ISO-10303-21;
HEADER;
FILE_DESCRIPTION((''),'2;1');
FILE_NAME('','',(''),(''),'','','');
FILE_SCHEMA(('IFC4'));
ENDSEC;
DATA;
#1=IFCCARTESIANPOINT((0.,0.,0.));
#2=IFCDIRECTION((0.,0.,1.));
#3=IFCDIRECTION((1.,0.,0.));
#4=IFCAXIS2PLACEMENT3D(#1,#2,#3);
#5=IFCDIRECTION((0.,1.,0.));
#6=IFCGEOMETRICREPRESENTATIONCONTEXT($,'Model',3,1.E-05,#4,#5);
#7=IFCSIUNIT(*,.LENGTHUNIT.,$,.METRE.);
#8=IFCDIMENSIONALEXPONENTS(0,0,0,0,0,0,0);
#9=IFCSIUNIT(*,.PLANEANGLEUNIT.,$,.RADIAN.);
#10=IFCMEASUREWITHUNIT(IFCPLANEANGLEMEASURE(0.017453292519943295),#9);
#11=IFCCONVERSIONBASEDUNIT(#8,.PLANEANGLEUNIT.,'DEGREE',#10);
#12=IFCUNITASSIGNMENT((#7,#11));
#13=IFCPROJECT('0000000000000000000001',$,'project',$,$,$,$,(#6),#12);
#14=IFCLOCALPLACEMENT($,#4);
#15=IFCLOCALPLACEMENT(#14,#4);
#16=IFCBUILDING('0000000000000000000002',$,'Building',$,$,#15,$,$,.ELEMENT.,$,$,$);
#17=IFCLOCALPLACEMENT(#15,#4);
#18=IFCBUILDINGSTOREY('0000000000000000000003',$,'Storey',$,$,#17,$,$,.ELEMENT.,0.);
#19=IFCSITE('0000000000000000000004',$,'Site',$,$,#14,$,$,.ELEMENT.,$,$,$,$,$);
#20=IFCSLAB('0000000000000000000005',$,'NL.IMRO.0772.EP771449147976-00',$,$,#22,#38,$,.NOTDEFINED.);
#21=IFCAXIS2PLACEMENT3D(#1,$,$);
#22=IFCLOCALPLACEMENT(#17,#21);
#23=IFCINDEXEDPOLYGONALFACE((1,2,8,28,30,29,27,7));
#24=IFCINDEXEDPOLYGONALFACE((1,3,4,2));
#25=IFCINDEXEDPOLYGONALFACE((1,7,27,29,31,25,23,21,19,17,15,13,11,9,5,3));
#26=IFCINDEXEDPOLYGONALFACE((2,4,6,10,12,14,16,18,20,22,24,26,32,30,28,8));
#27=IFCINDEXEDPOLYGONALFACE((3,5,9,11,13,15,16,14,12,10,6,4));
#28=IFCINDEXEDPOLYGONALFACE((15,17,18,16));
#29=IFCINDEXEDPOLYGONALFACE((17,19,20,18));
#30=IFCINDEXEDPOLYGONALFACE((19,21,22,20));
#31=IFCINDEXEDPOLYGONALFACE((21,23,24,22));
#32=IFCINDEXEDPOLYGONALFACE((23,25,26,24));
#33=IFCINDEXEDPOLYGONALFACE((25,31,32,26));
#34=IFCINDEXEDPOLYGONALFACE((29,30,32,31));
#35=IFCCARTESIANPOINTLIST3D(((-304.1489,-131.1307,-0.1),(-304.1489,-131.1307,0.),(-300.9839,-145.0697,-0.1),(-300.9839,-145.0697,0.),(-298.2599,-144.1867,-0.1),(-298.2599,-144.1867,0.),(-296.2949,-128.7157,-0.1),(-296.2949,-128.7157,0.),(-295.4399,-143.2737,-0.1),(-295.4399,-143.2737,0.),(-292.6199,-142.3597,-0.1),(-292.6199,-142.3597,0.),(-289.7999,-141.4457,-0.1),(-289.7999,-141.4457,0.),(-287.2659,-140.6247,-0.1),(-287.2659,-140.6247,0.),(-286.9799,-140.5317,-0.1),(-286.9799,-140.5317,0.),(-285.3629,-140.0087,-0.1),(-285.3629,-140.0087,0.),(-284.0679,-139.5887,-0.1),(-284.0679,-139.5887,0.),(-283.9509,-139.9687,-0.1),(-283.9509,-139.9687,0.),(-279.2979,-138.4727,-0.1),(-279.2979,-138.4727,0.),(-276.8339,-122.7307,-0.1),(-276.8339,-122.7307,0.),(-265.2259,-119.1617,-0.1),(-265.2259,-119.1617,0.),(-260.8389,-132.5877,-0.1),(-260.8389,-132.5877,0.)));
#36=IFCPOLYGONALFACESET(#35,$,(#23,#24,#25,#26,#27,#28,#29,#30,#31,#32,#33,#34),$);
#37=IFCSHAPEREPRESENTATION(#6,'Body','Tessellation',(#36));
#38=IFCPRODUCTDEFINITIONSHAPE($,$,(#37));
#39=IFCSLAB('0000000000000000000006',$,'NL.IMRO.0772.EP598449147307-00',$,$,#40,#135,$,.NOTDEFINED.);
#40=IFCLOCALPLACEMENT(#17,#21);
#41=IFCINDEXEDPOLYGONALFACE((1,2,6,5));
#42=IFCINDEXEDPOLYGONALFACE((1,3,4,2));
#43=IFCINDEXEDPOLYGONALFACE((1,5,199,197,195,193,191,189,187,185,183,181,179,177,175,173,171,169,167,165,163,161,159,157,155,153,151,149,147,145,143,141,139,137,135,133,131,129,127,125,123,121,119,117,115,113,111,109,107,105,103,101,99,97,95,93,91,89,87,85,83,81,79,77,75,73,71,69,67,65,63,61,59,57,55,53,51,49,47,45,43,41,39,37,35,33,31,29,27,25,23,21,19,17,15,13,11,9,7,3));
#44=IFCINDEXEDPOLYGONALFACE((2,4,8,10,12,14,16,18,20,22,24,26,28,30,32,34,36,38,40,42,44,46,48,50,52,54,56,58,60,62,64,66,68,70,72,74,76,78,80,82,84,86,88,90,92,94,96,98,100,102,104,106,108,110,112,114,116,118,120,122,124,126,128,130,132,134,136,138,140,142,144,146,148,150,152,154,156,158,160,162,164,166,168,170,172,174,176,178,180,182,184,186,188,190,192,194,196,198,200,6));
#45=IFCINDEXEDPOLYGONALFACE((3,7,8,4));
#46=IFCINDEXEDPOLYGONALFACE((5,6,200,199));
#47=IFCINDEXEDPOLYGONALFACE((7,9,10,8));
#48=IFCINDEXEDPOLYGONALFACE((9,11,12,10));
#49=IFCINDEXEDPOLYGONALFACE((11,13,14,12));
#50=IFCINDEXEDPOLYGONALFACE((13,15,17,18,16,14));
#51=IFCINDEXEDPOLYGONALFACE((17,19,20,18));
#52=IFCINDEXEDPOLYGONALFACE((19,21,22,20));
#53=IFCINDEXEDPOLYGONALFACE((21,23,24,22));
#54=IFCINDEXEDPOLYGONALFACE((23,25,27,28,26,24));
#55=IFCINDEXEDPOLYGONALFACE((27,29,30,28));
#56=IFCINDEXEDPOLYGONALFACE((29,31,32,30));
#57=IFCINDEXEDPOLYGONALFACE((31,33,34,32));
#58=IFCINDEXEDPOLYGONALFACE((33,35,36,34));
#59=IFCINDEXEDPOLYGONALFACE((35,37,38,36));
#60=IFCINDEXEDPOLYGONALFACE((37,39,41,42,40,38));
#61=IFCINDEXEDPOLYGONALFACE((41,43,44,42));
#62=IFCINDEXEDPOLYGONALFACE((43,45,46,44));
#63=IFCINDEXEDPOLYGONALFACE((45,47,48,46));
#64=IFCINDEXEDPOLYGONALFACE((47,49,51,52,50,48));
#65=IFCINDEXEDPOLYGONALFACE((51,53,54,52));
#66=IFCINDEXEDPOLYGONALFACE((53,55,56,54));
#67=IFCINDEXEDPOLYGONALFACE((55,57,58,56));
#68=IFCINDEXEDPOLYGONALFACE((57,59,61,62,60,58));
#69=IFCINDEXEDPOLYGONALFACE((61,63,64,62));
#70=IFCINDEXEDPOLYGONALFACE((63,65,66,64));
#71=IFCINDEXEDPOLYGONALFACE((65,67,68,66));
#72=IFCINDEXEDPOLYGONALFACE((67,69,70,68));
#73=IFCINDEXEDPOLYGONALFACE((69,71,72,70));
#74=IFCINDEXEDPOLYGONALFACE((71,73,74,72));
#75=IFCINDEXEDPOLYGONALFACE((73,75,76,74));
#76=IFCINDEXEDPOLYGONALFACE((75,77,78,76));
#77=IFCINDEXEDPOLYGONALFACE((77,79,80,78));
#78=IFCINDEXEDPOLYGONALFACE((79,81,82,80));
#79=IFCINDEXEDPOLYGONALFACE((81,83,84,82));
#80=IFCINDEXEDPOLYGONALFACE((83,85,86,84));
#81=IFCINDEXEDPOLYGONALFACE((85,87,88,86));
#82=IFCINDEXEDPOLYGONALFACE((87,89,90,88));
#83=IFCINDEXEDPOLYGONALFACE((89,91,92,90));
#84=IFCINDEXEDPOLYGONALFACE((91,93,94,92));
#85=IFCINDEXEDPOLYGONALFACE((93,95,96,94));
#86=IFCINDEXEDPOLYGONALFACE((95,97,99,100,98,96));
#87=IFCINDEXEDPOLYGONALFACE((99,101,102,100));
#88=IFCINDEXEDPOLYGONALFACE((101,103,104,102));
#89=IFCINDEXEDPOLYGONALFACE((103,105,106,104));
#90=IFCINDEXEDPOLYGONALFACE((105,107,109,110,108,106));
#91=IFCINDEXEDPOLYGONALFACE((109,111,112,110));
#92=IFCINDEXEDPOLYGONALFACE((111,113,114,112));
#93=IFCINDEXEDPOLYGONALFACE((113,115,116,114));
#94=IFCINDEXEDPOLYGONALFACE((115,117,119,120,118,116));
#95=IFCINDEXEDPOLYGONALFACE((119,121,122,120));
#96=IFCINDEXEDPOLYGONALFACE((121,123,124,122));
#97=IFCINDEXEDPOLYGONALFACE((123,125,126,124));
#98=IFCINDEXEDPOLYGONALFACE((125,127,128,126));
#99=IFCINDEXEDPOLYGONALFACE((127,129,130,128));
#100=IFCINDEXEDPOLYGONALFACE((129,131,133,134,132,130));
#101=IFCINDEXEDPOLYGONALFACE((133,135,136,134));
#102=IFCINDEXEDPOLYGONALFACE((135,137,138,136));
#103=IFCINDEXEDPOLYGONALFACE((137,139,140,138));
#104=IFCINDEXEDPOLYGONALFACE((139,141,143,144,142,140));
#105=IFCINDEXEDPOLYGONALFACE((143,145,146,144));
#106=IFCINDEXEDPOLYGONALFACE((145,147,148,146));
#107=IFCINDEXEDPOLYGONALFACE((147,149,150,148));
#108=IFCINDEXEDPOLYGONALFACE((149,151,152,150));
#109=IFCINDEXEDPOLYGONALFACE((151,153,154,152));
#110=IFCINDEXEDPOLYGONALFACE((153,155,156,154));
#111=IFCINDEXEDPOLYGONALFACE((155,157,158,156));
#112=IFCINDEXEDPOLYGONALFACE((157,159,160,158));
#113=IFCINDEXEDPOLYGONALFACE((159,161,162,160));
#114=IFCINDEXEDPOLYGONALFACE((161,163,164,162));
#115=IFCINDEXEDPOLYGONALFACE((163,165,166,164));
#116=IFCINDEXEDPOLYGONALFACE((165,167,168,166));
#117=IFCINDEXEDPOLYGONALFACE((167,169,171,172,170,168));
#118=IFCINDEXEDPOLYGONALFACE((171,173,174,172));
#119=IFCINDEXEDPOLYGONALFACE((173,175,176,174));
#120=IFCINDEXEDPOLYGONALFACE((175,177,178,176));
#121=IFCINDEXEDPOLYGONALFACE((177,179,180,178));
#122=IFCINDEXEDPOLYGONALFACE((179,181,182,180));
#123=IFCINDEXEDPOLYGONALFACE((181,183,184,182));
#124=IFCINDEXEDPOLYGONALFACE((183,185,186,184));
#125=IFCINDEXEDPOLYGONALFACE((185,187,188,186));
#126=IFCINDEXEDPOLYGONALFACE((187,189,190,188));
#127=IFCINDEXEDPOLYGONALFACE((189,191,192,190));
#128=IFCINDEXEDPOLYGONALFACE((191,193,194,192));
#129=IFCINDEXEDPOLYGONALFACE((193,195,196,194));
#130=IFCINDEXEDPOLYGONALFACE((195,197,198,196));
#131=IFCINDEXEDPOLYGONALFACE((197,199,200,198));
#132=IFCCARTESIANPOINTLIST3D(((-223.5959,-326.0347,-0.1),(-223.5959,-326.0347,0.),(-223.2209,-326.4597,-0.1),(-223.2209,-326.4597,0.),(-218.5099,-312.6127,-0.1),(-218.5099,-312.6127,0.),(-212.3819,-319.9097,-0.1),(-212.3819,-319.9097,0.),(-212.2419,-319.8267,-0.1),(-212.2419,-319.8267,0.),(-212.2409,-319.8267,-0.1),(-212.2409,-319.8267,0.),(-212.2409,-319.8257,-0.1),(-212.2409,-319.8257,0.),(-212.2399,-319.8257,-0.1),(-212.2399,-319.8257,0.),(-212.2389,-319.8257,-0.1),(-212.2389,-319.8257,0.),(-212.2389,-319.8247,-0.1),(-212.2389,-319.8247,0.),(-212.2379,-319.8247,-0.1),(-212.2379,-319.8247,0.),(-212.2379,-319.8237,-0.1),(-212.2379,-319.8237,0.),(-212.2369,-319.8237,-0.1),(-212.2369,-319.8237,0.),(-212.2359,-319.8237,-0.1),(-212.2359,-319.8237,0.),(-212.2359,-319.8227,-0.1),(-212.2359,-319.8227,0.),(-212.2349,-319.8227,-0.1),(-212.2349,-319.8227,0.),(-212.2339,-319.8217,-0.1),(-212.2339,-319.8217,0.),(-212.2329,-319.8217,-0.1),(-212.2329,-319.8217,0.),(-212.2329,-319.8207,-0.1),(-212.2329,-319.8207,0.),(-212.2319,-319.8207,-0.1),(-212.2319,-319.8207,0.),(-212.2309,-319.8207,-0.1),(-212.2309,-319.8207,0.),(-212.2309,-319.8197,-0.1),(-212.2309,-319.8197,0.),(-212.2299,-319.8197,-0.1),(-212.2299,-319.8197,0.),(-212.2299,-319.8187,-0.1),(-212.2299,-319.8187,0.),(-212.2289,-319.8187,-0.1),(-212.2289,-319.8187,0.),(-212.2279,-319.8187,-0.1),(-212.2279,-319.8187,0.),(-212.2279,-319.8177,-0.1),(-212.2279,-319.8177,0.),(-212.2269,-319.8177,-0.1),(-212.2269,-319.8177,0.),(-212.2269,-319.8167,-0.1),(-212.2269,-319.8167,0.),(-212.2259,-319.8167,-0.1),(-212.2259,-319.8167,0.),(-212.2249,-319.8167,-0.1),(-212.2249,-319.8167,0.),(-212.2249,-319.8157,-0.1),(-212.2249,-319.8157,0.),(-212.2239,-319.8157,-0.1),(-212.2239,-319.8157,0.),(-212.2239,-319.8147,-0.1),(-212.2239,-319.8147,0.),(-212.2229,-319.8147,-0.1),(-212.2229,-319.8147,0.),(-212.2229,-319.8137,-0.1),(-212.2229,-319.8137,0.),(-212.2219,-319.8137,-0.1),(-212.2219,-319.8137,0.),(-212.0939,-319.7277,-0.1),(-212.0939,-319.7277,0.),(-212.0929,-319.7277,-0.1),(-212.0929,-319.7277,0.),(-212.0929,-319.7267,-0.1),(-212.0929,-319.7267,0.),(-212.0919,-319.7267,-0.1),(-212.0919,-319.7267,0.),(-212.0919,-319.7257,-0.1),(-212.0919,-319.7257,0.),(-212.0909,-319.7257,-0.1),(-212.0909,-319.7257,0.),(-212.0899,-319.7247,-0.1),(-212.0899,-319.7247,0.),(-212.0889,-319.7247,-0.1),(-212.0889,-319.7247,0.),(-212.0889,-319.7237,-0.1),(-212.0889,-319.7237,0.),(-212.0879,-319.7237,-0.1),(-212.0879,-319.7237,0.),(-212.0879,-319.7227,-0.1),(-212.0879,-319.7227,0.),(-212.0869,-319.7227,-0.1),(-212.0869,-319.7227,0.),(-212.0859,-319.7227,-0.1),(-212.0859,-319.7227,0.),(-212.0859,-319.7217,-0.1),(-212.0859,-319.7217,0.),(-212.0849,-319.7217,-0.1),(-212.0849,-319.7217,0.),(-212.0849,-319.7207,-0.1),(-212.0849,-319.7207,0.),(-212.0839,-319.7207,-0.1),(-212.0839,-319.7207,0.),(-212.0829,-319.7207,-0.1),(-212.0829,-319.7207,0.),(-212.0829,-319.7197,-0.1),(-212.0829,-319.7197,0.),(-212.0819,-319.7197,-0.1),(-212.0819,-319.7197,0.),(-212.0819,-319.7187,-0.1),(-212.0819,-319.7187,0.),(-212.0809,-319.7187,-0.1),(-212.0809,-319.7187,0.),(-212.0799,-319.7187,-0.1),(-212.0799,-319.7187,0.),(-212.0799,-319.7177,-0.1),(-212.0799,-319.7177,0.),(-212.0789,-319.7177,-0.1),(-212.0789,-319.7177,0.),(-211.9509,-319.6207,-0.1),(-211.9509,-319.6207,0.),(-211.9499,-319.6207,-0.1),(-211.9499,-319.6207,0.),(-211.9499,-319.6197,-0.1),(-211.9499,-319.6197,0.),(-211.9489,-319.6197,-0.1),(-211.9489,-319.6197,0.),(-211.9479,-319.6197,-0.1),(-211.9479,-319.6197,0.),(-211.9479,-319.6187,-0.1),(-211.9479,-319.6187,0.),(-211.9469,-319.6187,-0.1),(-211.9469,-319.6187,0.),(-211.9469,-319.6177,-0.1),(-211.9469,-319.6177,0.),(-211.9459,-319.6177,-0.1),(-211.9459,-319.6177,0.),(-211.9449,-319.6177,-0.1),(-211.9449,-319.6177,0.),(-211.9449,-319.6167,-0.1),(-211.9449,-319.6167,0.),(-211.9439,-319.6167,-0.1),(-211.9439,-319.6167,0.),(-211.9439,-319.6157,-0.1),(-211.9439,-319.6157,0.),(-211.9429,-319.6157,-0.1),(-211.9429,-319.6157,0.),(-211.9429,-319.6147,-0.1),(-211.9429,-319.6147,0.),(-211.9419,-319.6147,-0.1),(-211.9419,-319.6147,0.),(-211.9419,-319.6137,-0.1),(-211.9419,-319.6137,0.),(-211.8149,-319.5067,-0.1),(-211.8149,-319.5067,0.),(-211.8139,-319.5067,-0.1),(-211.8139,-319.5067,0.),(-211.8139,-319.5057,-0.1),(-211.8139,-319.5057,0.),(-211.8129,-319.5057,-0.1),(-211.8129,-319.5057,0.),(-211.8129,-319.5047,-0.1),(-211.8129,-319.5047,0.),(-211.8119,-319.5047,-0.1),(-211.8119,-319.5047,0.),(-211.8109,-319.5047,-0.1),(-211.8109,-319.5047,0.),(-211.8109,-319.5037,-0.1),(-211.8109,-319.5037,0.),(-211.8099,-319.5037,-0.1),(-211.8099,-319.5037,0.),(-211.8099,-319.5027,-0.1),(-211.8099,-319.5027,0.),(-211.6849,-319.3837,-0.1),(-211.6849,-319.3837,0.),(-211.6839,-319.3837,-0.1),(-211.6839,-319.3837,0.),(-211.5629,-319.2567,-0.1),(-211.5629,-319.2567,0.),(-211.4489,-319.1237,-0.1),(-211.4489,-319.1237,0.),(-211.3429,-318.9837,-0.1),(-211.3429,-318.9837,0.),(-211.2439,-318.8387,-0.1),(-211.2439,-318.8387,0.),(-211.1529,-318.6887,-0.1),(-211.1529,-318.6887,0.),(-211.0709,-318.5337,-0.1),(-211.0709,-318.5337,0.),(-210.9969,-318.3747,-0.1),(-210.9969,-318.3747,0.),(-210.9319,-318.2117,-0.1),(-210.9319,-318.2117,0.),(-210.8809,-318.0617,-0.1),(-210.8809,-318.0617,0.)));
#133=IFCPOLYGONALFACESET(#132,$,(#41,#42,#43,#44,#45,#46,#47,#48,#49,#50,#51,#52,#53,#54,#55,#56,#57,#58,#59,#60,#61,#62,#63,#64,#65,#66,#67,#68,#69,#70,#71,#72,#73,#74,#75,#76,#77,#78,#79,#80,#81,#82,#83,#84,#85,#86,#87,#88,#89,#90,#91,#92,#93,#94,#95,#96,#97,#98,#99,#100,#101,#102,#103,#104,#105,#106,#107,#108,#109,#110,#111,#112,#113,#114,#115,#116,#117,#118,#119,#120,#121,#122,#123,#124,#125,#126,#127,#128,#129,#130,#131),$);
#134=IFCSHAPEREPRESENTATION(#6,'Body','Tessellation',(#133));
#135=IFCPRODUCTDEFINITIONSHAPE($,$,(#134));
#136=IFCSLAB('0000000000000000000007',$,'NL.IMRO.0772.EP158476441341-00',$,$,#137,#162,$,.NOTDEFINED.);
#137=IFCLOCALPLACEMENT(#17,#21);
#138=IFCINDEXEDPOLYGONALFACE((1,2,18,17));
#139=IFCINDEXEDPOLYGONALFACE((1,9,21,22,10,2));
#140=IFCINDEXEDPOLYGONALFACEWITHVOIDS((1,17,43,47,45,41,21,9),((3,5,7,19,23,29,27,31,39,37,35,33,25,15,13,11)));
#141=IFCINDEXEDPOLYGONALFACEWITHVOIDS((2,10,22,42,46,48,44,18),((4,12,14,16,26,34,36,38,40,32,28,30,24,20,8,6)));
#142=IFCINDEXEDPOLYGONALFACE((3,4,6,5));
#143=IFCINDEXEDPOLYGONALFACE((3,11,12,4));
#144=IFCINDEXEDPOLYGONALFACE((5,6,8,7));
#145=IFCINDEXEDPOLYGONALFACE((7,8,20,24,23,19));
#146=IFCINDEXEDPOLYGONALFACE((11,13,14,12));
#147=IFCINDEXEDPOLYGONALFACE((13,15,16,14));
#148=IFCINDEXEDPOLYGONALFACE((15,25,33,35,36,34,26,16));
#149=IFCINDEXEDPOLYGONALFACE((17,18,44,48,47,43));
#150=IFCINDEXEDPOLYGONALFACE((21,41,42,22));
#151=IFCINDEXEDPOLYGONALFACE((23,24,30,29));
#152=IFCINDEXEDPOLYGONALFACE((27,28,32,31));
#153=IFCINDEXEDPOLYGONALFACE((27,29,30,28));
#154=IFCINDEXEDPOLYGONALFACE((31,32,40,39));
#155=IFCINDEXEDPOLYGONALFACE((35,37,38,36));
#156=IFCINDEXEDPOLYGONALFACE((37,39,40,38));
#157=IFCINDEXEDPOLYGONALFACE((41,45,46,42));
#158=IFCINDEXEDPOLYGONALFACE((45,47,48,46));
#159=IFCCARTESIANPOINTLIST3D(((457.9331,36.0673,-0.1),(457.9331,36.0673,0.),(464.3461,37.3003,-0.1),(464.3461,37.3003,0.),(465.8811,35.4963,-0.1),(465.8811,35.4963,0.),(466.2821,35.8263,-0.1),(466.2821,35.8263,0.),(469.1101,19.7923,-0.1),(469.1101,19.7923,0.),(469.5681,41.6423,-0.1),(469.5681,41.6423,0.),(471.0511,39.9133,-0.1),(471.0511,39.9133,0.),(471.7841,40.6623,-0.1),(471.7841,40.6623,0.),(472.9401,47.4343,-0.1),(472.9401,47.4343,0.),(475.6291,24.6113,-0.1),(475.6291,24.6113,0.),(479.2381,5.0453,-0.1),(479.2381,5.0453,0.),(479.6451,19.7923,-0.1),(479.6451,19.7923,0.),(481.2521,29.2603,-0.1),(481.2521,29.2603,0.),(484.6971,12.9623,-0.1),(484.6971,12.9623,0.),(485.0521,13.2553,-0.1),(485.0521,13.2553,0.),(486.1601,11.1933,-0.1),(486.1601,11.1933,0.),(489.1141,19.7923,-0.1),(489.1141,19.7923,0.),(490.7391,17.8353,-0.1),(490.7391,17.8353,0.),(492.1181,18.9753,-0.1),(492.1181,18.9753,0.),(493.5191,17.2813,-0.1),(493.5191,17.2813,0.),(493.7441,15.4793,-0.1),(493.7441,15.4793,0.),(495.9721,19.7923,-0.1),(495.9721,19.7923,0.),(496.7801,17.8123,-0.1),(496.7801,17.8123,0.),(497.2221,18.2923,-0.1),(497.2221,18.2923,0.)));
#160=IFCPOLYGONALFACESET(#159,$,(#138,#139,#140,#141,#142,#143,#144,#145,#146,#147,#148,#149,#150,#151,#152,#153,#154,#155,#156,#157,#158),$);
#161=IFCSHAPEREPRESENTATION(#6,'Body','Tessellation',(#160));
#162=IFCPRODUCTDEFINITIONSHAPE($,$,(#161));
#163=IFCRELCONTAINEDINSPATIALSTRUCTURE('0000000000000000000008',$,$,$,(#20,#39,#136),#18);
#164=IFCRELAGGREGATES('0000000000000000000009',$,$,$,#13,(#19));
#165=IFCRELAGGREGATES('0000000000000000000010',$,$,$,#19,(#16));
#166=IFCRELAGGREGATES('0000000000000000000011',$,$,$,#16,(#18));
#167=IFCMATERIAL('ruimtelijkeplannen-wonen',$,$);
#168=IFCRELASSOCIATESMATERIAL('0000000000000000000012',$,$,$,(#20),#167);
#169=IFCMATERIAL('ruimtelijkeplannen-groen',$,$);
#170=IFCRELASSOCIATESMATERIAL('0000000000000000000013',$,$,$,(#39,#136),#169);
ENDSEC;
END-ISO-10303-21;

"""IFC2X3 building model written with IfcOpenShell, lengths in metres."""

from ifc_helpers import new_model, entity, si_unit, converted_unit, direction, frame, origin_with_axes, place, context, project, spatial, polyline, outline, extrude, material, element, save


model = new_model("IFC2X3")

# Units and contexts
model_context = context("Model", 3, precision=1e-05, world=origin_with_axes(), true_north=direction((0.0, 1.0, 0.0)))
ifc_project = project(units=[si_unit("LENGTHUNIT", "METRE"), converted_unit("PLANEANGLEUNIT", "DEGREE", entity("IfcPlaneAngleMeasure", 0.017453292519943295), si_unit("PLANEANGLEUNIT", "RADIAN"), dimensions=[0, 0, 0, 0, 0, 0, 0])], contexts=[model_context])

# Site, building, storey
site_placement = place(None, origin_with_axes())
site = spatial("IfcSite", under=ifc_project, at=site_placement, Name="Site", CompositionType="ELEMENT")
building_placement = place(site_placement, origin_with_axes())
building = spatial("IfcBuilding", under=site, at=building_placement, Name="Building", CompositionType="ELEMENT")
storey_placement = place(building_placement, origin_with_axes())
storey = spatial("IfcBuildingStorey", under=building, at=storey_placement, Name="Storey", CompositionType="ELEMENT", Elevation=0.0)

# Slabs
ifc_material_1 = material(Name="ruimtelijkeplannen-wonen")
slab_1_placement = place(storey_placement, frame((0.0, 0.0, -0.1), z_axis=(0.0, 0.0, 1.0), x_axis=(1.0, 0.0, 0.0)))
element("IfcSlab", 1, at=slab_1_placement, inside=storey, material=ifc_material_1, Name="NL.IMRO.0772.EP771449147976-00", PredefinedType="NOTDEFINED", context=model_context, shape_type="SweptSolid", body=[
    extrude(outline(polyline([(-260.8389, -132.5877), (-279.2979, -138.4727), (-283.9509, -139.9687), (-284.0679, -139.5887), (-285.3629, -140.0087), (-286.9799, -140.5317), (-287.2659, -140.6247), (-289.7999, -141.4457), (-292.6199, -142.3597), (-295.4399, -143.2737), (-298.2599, -144.1867), (-300.9839, -145.0697), (-304.1489, -131.1307), (-296.2949, -128.7157), (-276.8339, -122.7307), (-265.2259, -119.1617), (-260.8389, -132.5877)])), origin_with_axes(), (0.0, 0.0, 1.0), 0.1),
])
ifc_material_2 = material(Name="ruimtelijkeplannen-groen")
slab_2_placement = place(storey_placement, frame((0.0, 0.0, -0.1), z_axis=(0.0, 0.0, 1.0), x_axis=(1.0, 0.0, 0.0)))
element("IfcSlab", 2, at=slab_2_placement, inside=storey, material=ifc_material_2, Name="NL.IMRO.0772.EP598449147307-00", PredefinedType="NOTDEFINED", context=model_context, shape_type="SweptSolid", body=[
    extrude(outline(polyline([(-212.2219, -319.8137), (-212.2229, -319.8137), (-212.2229, -319.8147), (-212.2239, -319.8147), (-212.2239, -319.8157), (-212.2249, -319.8157), (-212.2249, -319.8167), (-212.2259, -319.8167), (-212.2269, -319.8167), (-212.2269, -319.8177), (-212.2279, -319.8177), (-212.2279, -319.8187), (-212.2289, -319.8187), (-212.2299, -319.8187), (-212.2299, -319.8197), (-212.2309, -319.8197), (-212.2309, -319.8207), (-212.2319, -319.8207), (-212.2329, -319.8207), (-212.2329, -319.8217), (-212.2339, -319.8217), (-212.2349, -319.8227), (-212.2359, -319.8227), (-212.2359, -319.8237), (-212.2369, -319.8237), (-212.2379, -319.8237), (-212.2379, -319.8247), (-212.2389, -319.8247), (-212.2389, -319.8257), (-212.2399, -319.8257), (-212.2409, -319.8257), (-212.2409, -319.8267), (-212.2419, -319.8267), (-212.3819, -319.9097), (-223.2209, -326.4597), (-223.5959, -326.0347), (-218.5099, -312.6127), (-210.8809, -318.0617), (-210.9319, -318.2117), (-210.9969, -318.3747), (-211.0709, -318.5337), (-211.1529, -318.6887), (-211.2439, -318.8387), (-211.3429, -318.9837), (-211.4489, -319.1237), (-211.5629, -319.2567), (-211.6839, -319.3837), (-211.6849, -319.3837), (-211.8099, -319.5027), (-211.8099, -319.5037), (-211.8109, -319.5037), (-211.8109, -319.5047), (-211.8119, -319.5047), (-211.8129, -319.5047), (-211.8129, -319.5057), (-211.8139, -319.5057), (-211.8139, -319.5067), (-211.8149, -319.5067), (-211.9419, -319.6137), (-211.9419, -319.6147), (-211.9429, -319.6147), (-211.9429, -319.6157), (-211.9439, -319.6157), (-211.9439, -319.6167), (-211.9449, -319.6167), (-211.9449, -319.6177), (-211.9459, -319.6177), (-211.9469, -319.6177), (-211.9469, -319.6187), (-211.9479, -319.6187), (-211.9479, -319.6197), (-211.9489, -319.6197), (-211.9499, -319.6197), (-211.9499, -319.6207), (-211.9509, -319.6207), (-212.0789, -319.7177), (-212.0799, -319.7177), (-212.0799, -319.7187), (-212.0809, -319.7187), (-212.0819, -319.7187), (-212.0819, -319.7197), (-212.0829, -319.7197), (-212.0829, -319.7207), (-212.0839, -319.7207), (-212.0849, -319.7207), (-212.0849, -319.7217), (-212.0859, -319.7217), (-212.0859, -319.7227), (-212.0869, -319.7227), (-212.0879, -319.7227), (-212.0879, -319.7237), (-212.0889, -319.7237), (-212.0889, -319.7247), (-212.0899, -319.7247), (-212.0909, -319.7257), (-212.0919, -319.7257), (-212.0919, -319.7267), (-212.0929, -319.7267), (-212.0929, -319.7277), (-212.0939, -319.7277), (-212.2219, -319.8137)])), origin_with_axes(), (0.0, 0.0, 1.0), 0.1),
])
slab_3_placement = place(storey_placement, frame((0.0, 0.0, -0.1), z_axis=(0.0, 0.0, 1.0), x_axis=(1.0, 0.0, 0.0)))
element("IfcSlab", 3, at=slab_3_placement, inside=storey, material=ifc_material_2, Name="NL.IMRO.0772.EP158476441341-00", PredefinedType="NOTDEFINED", context=model_context, shape_type="SweptSolid", body=[
    extrude(outline(polyline([(493.7441, 15.4793), (479.2381, 5.0453), (469.1101, 19.7923), (457.9331, 36.0673), (472.9401, 47.4343), (495.9721, 19.7923), (497.2221, 18.2923), (496.7801, 17.8123), (493.7441, 15.4793)]), holes=[polyline([(471.7841, 40.6623), (471.0511, 39.9133), (469.5681, 41.6423), (464.3461, 37.3003), (465.8811, 35.4963), (466.2821, 35.8263), (475.6291, 24.6113), (479.6451, 19.7923), (485.0521, 13.2553), (484.6971, 12.9623), (486.1601, 11.1933), (493.5191, 17.2813), (492.1181, 18.9753), (490.7391, 17.8353), (489.1141, 19.7923), (481.2521, 29.2603), (471.7841, 40.6623)])]), origin_with_axes(), (0.0, 0.0, 1.0), 0.1),
])

save(model, "model.ifc")
